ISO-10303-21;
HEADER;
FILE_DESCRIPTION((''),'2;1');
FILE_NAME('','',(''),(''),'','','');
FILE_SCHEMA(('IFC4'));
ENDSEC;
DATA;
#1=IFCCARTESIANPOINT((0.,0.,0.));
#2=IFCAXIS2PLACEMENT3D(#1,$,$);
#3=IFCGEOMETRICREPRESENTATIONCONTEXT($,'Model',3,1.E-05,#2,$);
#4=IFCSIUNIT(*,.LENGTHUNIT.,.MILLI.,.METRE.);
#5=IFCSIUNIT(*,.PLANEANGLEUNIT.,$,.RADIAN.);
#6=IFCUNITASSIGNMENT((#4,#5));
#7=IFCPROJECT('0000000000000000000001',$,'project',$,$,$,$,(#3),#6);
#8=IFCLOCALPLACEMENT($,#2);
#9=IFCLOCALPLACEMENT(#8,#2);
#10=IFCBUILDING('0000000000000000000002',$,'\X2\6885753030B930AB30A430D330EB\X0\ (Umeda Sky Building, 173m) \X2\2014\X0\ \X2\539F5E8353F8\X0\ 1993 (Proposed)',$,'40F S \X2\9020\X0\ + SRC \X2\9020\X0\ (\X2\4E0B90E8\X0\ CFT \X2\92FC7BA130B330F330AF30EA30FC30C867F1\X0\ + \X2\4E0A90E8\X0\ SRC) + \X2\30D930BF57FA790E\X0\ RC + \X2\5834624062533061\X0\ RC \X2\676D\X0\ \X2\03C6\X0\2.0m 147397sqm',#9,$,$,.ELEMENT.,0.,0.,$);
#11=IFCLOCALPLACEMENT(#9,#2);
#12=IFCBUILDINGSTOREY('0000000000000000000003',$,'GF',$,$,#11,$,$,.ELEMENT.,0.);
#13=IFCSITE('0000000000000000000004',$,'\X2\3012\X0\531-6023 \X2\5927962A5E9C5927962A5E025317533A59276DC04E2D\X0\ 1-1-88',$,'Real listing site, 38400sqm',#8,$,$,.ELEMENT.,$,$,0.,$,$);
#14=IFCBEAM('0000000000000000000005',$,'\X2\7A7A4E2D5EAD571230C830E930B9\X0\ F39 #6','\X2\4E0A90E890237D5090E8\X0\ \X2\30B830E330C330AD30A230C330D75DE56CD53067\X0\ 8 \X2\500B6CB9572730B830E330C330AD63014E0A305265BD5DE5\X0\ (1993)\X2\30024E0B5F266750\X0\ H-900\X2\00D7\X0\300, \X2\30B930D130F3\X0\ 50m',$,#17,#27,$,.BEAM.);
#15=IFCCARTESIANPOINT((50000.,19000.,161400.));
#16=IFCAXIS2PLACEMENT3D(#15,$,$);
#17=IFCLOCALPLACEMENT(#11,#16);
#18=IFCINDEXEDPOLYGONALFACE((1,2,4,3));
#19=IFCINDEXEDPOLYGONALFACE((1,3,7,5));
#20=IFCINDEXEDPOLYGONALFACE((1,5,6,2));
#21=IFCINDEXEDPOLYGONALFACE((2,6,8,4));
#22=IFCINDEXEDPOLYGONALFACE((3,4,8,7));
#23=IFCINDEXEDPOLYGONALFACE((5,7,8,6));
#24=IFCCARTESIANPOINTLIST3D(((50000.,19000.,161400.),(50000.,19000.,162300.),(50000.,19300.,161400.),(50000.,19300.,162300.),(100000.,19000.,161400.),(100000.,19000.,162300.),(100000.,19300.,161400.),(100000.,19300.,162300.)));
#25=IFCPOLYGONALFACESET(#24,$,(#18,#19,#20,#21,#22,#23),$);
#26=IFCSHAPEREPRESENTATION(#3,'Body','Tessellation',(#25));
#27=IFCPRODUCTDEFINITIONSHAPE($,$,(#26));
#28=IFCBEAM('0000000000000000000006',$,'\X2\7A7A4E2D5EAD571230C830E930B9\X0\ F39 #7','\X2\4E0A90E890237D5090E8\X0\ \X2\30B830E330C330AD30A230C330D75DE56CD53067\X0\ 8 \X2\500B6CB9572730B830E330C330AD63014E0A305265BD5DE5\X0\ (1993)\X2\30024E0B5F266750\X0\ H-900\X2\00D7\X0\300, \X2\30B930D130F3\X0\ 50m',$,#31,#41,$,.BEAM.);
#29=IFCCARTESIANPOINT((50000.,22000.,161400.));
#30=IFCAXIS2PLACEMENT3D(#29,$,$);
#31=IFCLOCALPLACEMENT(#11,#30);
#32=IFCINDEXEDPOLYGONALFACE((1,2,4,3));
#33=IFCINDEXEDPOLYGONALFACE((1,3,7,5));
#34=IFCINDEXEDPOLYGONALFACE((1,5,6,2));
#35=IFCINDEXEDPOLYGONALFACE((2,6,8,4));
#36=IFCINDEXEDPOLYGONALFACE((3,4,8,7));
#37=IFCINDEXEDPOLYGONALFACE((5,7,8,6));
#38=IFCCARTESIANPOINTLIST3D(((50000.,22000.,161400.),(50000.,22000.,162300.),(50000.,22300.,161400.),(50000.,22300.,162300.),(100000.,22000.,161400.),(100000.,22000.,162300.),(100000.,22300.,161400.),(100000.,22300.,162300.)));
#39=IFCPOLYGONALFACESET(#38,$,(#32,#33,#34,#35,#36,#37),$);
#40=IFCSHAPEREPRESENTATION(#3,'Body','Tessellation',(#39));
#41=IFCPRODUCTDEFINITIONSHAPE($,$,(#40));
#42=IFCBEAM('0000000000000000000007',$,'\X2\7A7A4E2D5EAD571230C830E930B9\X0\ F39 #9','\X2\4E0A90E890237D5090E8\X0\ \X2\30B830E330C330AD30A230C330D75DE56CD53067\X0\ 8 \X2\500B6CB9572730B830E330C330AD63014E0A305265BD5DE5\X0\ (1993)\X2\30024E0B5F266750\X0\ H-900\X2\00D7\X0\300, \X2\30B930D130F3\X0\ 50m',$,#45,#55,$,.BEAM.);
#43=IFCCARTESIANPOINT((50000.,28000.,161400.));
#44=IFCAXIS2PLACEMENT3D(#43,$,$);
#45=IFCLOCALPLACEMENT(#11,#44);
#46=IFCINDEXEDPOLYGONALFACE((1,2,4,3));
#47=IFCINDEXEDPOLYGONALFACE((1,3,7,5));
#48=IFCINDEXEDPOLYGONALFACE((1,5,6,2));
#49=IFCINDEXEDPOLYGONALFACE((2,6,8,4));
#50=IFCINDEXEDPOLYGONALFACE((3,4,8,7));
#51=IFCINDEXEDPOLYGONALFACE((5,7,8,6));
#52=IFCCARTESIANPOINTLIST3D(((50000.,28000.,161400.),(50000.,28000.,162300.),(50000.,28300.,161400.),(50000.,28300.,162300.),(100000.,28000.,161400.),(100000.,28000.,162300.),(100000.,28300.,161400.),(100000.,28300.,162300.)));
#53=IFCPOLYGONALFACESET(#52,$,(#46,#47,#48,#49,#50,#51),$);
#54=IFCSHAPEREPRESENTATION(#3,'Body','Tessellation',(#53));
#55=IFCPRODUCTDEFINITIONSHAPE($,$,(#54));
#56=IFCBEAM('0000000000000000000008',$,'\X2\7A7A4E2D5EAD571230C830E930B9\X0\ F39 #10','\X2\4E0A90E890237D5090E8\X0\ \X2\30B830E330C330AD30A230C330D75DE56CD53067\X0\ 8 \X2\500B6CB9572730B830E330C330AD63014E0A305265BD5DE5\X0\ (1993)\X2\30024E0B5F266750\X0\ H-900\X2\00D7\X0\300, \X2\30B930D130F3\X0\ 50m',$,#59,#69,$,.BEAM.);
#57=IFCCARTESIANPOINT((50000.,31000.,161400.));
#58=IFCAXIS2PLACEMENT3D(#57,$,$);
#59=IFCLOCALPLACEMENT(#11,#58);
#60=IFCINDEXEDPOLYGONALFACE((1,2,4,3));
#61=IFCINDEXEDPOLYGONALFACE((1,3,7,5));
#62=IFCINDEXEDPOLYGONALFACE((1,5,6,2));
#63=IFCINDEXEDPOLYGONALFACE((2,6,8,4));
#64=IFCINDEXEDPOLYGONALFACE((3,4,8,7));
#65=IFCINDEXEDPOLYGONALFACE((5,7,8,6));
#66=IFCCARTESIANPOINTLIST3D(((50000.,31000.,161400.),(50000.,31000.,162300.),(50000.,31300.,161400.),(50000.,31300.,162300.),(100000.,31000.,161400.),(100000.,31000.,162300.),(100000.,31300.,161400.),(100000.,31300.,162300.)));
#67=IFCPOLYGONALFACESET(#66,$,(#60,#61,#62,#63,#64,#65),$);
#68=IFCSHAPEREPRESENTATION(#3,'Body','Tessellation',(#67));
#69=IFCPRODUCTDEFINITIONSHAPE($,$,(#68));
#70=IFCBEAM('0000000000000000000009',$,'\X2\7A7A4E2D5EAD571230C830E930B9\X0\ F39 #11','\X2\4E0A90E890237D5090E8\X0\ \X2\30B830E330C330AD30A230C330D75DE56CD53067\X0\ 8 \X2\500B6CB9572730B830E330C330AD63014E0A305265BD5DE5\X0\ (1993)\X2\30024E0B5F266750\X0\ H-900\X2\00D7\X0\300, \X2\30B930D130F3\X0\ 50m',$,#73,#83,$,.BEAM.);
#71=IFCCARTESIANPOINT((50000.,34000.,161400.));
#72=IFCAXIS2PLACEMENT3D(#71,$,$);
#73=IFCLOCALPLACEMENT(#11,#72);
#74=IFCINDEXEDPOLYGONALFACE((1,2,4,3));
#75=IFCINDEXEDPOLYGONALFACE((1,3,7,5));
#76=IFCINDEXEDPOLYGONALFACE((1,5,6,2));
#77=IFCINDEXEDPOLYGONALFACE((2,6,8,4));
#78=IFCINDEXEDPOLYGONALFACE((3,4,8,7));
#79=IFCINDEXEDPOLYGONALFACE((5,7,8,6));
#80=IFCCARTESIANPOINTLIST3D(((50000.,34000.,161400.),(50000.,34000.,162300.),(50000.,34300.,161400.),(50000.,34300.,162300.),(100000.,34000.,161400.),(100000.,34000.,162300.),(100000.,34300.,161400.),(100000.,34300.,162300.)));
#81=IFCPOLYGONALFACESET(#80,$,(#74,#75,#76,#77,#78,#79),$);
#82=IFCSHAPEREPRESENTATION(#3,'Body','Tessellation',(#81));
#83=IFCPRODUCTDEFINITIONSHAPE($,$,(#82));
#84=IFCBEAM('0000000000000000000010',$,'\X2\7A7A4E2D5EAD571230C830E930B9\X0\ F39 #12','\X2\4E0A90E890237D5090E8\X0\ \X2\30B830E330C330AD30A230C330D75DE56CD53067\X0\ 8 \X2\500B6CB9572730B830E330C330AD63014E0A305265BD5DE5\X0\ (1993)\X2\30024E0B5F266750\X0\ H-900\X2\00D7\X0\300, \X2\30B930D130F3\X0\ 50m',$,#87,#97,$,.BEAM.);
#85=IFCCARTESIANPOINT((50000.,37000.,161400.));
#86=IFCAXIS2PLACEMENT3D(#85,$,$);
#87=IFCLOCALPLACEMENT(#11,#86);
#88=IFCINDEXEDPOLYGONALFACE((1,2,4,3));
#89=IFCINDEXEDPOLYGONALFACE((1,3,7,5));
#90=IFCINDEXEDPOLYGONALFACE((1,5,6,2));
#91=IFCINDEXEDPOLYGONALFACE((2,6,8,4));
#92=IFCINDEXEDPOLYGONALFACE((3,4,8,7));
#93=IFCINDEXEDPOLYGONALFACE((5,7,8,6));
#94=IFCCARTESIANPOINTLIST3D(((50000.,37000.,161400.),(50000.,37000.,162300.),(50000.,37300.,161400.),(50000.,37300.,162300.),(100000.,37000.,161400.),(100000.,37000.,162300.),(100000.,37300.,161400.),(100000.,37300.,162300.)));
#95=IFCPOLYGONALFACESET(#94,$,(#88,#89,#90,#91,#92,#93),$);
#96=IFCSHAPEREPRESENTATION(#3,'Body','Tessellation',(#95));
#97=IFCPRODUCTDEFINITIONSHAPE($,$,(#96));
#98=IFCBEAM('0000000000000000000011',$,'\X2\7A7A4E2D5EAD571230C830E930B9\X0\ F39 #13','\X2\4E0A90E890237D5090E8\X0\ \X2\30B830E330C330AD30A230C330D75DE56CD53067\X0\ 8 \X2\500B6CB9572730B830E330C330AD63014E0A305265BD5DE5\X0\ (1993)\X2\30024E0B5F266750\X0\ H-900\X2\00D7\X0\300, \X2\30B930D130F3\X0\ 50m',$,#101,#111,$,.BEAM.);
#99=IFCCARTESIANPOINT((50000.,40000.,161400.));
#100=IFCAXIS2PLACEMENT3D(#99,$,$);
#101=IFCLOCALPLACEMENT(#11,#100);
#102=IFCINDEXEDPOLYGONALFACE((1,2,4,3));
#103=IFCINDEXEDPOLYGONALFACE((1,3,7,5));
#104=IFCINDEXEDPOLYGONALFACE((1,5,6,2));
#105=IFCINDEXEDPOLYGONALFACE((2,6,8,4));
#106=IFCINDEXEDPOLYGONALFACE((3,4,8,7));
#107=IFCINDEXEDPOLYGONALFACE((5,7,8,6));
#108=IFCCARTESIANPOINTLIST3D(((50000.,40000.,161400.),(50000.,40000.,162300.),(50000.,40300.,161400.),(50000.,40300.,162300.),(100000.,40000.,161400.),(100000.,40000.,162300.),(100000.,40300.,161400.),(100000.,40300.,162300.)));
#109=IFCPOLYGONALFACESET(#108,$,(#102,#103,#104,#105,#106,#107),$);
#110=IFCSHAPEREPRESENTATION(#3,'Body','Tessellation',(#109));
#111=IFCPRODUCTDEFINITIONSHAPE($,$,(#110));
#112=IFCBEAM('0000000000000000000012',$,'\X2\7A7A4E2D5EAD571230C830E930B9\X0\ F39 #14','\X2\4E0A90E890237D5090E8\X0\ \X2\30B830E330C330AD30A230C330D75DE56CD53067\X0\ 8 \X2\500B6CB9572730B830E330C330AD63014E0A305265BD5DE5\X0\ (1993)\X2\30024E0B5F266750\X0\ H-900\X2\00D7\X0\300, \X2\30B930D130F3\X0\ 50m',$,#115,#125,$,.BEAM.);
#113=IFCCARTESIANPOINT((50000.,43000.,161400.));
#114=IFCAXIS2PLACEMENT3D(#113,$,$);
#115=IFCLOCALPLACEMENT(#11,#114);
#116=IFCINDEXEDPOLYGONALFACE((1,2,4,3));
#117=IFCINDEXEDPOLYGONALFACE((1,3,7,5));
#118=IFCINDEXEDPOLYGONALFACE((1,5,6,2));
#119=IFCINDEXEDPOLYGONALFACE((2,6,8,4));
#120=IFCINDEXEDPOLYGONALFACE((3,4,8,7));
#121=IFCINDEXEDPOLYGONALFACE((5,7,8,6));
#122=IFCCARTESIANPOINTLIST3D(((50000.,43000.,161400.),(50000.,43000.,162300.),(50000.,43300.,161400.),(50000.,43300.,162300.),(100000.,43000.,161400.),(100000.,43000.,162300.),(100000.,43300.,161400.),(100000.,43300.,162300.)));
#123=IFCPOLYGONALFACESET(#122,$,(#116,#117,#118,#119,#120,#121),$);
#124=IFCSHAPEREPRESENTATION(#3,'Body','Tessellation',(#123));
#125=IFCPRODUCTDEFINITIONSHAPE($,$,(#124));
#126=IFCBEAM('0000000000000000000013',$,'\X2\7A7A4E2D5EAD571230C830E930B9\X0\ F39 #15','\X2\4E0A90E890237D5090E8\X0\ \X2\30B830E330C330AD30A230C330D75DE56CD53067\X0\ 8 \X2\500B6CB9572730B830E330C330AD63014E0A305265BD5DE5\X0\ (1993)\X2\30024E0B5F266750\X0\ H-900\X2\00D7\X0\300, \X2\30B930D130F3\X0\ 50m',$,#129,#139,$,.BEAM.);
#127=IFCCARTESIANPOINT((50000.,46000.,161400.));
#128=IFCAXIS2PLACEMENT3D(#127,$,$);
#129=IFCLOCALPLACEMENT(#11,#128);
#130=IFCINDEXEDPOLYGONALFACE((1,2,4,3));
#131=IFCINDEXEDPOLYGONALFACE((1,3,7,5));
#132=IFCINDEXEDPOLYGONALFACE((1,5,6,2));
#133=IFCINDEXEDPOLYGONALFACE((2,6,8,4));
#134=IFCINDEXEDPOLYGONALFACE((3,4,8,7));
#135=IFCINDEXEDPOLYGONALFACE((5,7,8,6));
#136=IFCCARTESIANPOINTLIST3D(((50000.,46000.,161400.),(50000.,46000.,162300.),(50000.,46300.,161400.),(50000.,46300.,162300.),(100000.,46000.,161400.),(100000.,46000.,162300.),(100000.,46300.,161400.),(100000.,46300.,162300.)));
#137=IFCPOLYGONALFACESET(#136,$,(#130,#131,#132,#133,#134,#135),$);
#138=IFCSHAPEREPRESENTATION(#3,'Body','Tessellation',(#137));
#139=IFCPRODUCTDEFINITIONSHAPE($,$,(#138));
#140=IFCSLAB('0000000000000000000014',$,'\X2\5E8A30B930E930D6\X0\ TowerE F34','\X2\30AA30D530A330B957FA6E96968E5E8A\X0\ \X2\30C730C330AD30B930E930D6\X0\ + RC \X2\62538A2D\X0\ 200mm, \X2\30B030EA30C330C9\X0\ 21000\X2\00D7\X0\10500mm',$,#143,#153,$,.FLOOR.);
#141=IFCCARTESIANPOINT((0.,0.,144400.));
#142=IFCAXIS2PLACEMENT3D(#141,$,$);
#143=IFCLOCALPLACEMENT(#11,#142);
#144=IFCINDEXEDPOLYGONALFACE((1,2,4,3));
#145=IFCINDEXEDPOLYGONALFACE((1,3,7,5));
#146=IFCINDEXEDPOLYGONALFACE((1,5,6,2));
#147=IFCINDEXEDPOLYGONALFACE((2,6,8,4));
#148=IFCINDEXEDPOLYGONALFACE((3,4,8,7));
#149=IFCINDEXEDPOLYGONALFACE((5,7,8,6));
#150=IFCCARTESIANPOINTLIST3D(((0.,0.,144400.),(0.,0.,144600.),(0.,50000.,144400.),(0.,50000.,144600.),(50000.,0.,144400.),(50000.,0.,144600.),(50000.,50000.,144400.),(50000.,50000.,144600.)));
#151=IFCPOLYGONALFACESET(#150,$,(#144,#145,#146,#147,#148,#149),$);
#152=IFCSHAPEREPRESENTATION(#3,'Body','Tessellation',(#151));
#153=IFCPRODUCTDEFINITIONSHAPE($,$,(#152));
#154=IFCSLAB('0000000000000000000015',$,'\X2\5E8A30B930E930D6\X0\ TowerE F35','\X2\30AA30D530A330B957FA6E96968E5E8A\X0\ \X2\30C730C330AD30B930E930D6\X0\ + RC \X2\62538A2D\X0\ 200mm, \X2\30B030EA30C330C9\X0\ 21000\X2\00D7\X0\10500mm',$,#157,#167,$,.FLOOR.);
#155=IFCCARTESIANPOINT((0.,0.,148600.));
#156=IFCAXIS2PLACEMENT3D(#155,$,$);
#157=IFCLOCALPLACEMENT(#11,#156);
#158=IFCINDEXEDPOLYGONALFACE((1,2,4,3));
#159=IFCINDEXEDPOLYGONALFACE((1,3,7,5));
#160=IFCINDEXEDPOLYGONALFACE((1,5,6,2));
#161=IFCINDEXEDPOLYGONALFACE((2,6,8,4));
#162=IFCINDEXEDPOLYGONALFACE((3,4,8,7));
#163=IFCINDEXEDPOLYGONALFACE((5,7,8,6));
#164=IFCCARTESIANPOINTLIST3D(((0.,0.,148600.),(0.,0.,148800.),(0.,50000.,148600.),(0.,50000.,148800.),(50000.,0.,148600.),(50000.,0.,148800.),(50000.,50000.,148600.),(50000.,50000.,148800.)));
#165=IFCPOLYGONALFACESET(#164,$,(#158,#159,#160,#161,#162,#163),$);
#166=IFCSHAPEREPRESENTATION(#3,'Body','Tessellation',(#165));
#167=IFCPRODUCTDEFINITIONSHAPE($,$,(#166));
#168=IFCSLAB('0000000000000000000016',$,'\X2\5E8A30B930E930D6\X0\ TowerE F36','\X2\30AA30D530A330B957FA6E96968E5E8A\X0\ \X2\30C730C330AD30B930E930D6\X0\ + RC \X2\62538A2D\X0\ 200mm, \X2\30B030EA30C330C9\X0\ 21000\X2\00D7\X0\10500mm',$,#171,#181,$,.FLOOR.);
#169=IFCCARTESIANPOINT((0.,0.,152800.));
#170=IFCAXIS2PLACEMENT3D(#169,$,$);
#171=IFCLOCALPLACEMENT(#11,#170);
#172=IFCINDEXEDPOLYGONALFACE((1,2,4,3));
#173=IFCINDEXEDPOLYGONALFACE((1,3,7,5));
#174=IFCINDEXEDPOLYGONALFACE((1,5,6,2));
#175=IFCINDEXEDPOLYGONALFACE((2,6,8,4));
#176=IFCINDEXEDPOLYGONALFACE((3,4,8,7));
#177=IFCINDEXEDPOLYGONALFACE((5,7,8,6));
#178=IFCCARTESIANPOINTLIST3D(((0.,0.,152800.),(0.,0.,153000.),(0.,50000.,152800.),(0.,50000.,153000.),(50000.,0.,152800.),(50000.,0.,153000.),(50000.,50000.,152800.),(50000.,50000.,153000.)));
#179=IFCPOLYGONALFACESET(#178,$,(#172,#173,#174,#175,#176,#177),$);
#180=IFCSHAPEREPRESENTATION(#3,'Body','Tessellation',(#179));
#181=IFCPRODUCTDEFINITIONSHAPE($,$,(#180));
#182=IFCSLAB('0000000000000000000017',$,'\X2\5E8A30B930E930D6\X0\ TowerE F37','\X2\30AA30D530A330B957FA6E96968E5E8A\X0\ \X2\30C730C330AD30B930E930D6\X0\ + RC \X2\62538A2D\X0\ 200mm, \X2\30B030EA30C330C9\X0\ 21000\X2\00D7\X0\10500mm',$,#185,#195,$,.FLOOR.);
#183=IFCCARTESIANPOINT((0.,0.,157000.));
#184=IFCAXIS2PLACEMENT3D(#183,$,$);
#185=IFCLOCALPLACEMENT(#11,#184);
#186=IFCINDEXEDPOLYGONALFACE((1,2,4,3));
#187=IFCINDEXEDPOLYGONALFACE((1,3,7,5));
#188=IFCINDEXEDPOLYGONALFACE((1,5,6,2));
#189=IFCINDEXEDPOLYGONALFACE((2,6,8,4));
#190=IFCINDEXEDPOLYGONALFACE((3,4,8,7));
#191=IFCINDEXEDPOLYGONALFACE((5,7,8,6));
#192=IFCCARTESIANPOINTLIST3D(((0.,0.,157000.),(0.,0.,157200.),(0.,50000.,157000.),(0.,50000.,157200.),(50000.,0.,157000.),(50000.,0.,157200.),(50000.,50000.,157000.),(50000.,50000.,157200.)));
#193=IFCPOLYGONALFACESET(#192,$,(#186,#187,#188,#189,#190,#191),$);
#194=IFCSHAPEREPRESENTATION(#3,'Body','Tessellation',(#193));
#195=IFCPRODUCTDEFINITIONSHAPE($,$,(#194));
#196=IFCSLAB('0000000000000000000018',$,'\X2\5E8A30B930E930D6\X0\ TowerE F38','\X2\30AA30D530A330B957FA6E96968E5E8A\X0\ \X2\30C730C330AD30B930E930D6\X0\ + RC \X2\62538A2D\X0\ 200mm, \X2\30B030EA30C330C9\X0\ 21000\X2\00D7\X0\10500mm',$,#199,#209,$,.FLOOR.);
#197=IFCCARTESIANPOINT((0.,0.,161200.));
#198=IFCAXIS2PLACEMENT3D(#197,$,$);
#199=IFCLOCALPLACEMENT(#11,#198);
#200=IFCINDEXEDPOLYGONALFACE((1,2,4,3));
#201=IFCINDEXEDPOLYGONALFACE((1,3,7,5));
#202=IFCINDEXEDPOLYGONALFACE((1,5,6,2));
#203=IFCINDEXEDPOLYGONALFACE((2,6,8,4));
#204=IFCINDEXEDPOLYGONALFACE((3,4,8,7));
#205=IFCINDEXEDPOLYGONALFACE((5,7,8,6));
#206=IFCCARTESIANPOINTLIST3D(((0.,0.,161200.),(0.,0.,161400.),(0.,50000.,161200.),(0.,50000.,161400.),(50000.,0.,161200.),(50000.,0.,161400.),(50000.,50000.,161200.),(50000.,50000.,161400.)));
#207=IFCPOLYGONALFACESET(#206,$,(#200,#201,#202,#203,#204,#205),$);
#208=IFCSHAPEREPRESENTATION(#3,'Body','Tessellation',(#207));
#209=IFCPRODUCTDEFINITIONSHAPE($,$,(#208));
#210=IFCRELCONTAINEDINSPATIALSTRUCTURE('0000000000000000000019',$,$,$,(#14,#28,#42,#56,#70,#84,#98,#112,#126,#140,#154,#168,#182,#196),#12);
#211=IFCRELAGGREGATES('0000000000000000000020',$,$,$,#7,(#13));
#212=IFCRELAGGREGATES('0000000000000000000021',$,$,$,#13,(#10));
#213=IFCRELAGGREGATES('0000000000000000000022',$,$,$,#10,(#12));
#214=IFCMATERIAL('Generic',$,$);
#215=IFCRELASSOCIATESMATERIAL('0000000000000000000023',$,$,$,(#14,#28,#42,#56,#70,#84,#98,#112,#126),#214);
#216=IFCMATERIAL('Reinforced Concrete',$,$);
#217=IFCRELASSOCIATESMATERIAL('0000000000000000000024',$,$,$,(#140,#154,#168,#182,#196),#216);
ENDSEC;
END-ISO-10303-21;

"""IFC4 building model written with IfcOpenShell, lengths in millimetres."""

from ifc_helpers import new_model, si_unit, frame, frame_2d, origin, place, context, project, spatial, rectangle, extrude, material, element, save


model = new_model("IFC4")

# Units and contexts
model_context = context("Model", 3, precision=1e-05, world=origin())
ifc_project = project(units=[si_unit("LENGTHUNIT", "METRE", prefix="MILLI"), si_unit("PLANEANGLEUNIT", "RADIAN")], contexts=[model_context])

# Site, building, storey
site_placement = place(None, origin())
site = spatial("IfcSite", under=ifc_project, at=site_placement, Name="〒531-6023 大阪府大阪市北区大淀中 1-1-88", ObjectType="Real listing site, 38400sqm", CompositionType="ELEMENT", RefElevation=0.0)
building_placement = place(site_placement, origin())
building = spatial("IfcBuilding", under=site, at=building_placement, Name="梅田スカイビル (Umeda Sky Building, 173m) — 原広司 1993 (Proposed)", ObjectType="40F S 造 + SRC 造 (下部 CFT 鋼管コンクリート柱 + 上部 SRC) + ベタ基礎 RC + 場所打ち RC 杭 φ2.0m 147397sqm", CompositionType="ELEMENT", ElevationOfRefHeight=0.0, ElevationOfTerrain=0.0)
storey_placement = place(building_placement, origin())
storey = spatial("IfcBuildingStorey", under=building, at=storey_placement, Name="GF", CompositionType="ELEMENT", Elevation=0.0)

# Shared definitions
ifc_material_1 = material(Name="Reinforced Concrete")

# Beams
ifc_material_2 = material(Name="Generic")
beam_1_placement = place(storey_placement, frame((50000.0, 19000.0, 161400.0)))
element("IfcBeam", 1, at=beam_1_placement, inside=storey, material=ifc_material_2, Name="空中庭園トラス F39 #6", Description="上部連結部 ジャッキアップ工法で 8 個油圧ジャッキ持上げ施工 (1993)。下弦材 H-900×300, スパン 50m", PredefinedType="BEAM", context=model_context, shape_type="SweptSolid", body=[
    extrude(rectangle(XDim=50000.0, YDim=300.0, at=frame_2d((25000.0, 150.0))), frame((50000.0, 19000.0, 161400.0)), (0.0, 0.0, 1.0), 900.0),
])
beam_2_placement = place(storey_placement, frame((50000.0, 22000.0, 161400.0)))
element("IfcBeam", 2, at=beam_2_placement, inside=storey, material=ifc_material_2, Name="空中庭園トラス F39 #7", Description="上部連結部 ジャッキアップ工法で 8 個油圧ジャッキ持上げ施工 (1993)。下弦材 H-900×300, スパン 50m", PredefinedType="BEAM", context=model_context, shape_type="SweptSolid", body=[
    extrude(rectangle(XDim=50000.0, YDim=300.0, at=frame_2d((25000.0, 150.0))), frame((50000.0, 22000.0, 161400.0)), (0.0, 0.0, 1.0), 900.0),
])
beam_3_placement = place(storey_placement, frame((50000.0, 28000.0, 161400.0)))
element("IfcBeam", 3, at=beam_3_placement, inside=storey, material=ifc_material_2, Name="空中庭園トラス F39 #9", Description="上部連結部 ジャッキアップ工法で 8 個油圧ジャッキ持上げ施工 (1993)。下弦材 H-900×300, スパン 50m", PredefinedType="BEAM", context=model_context, shape_type="SweptSolid", body=[
    extrude(rectangle(XDim=50000.0, YDim=300.0, at=frame_2d((25000.0, 150.0))), frame((50000.0, 28000.0, 161400.0)), (0.0, 0.0, 1.0), 900.0),
])
beam_4_placement = place(storey_placement, frame((50000.0, 31000.0, 161400.0)))
element("IfcBeam", 4, at=beam_4_placement, inside=storey, material=ifc_material_2, Name="空中庭園トラス F39 #10", Description="上部連結部 ジャッキアップ工法で 8 個油圧ジャッキ持上げ施工 (1993)。下弦材 H-900×300, スパン 50m", PredefinedType="BEAM", context=model_context, shape_type="SweptSolid", body=[
    extrude(rectangle(XDim=50000.0, YDim=300.0, at=frame_2d((25000.0, 150.0))), frame((50000.0, 31000.0, 161400.0)), (0.0, 0.0, 1.0), 900.0),
])
beam_5_placement = place(storey_placement, frame((50000.0, 34000.0, 161400.0)))
element("IfcBeam", 5, at=beam_5_placement, inside=storey, material=ifc_material_2, Name="空中庭園トラス F39 #11", Description="上部連結部 ジャッキアップ工法で 8 個油圧ジャッキ持上げ施工 (1993)。下弦材 H-900×300, スパン 50m", PredefinedType="BEAM", context=model_context, shape_type="SweptSolid", body=[
    extrude(rectangle(XDim=50000.0, YDim=300.0, at=frame_2d((25000.0, 150.0))), frame((50000.0, 34000.0, 161400.0)), (0.0, 0.0, 1.0), 900.0),
])
beam_6_placement = place(storey_placement, frame((50000.0, 37000.0, 161400.0)))
element("IfcBeam", 6, at=beam_6_placement, inside=storey, material=ifc_material_2, Name="空中庭園トラス F39 #12", Description="上部連結部 ジャッキアップ工法で 8 個油圧ジャッキ持上げ施工 (1993)。下弦材 H-900×300, スパン 50m", PredefinedType="BEAM", context=model_context, shape_type="SweptSolid", body=[
    extrude(rectangle(XDim=50000.0, YDim=300.0, at=frame_2d((25000.0, 150.0))), frame((50000.0, 37000.0, 161400.0)), (0.0, 0.0, 1.0), 900.0),
])
beam_7_placement = place(storey_placement, frame((50000.0, 40000.0, 161400.0)))
element("IfcBeam", 7, at=beam_7_placement, inside=storey, material=ifc_material_2, Name="空中庭園トラス F39 #13", Description="上部連結部 ジャッキアップ工法で 8 個油圧ジャッキ持上げ施工 (1993)。下弦材 H-900×300, スパン 50m", PredefinedType="BEAM", context=model_context, shape_type="SweptSolid", body=[
    extrude(rectangle(XDim=50000.0, YDim=300.0, at=frame_2d((25000.0, 150.0))), frame((50000.0, 40000.0, 161400.0)), (0.0, 0.0, 1.0), 900.0),
])
beam_8_placement = place(storey_placement, frame((50000.0, 43000.0, 161400.0)))
element("IfcBeam", 8, at=beam_8_placement, inside=storey, material=ifc_material_2, Name="空中庭園トラス F39 #14", Description="上部連結部 ジャッキアップ工法で 8 個油圧ジャッキ持上げ施工 (1993)。下弦材 H-900×300, スパン 50m", PredefinedType="BEAM", context=model_context, shape_type="SweptSolid", body=[
    extrude(rectangle(XDim=50000.0, YDim=300.0, at=frame_2d((25000.0, 150.0))), frame((50000.0, 43000.0, 161400.0)), (0.0, 0.0, 1.0), 900.0),
])
beam_9_placement = place(storey_placement, frame((50000.0, 46000.0, 161400.0)))
element("IfcBeam", 9, at=beam_9_placement, inside=storey, material=ifc_material_2, Name="空中庭園トラス F39 #15", Description="上部連結部 ジャッキアップ工法で 8 個油圧ジャッキ持上げ施工 (1993)。下弦材 H-900×300, スパン 50m", PredefinedType="BEAM", context=model_context, shape_type="SweptSolid", body=[
    extrude(rectangle(XDim=50000.0, YDim=300.0, at=frame_2d((25000.0, 150.0))), frame((50000.0, 46000.0, 161400.0)), (0.0, 0.0, 1.0), 900.0),
])

# Slabs
slab_1_placement = place(storey_placement, frame((0.0, 0.0, 144400.0)))
element("IfcSlab", 10, at=slab_1_placement, inside=storey, material=ifc_material_1, Name="床スラブ TowerE F34", Description="オフィス基準階床 デッキスラブ + RC 打設 200mm, グリッド 21000×10500mm", PredefinedType="FLOOR", context=model_context, shape_type="SweptSolid", body=[
    extrude(rectangle(XDim=50000.0, YDim=50000.0, at=frame_2d((25000.0, 25000.0))), frame((0.0, 0.0, 144400.0)), (0.0, 0.0, 1.0), 200.0),
])
slab_2_placement = place(storey_placement, frame((0.0, 0.0, 148600.0)))
element("IfcSlab", 11, at=slab_2_placement, inside=storey, material=ifc_material_1, Name="床スラブ TowerE F35", Description="オフィス基準階床 デッキスラブ + RC 打設 200mm, グリッド 21000×10500mm", PredefinedType="FLOOR", context=model_context, shape_type="SweptSolid", body=[
    extrude(rectangle(XDim=50000.0, YDim=50000.0, at=frame_2d((25000.0, 25000.0))), frame((0.0, 0.0, 148600.0)), (0.0, 0.0, 1.0), 200.0),
])
slab_3_placement = place(storey_placement, frame((0.0, 0.0, 152800.0)))
element("IfcSlab", 12, at=slab_3_placement, inside=storey, material=ifc_material_1, Name="床スラブ TowerE F36", Description="オフィス基準階床 デッキスラブ + RC 打設 200mm, グリッド 21000×10500mm", PredefinedType="FLOOR", context=model_context, shape_type="SweptSolid", body=[
    extrude(rectangle(XDim=50000.0, YDim=50000.0, at=frame_2d((25000.0, 25000.0))), frame((0.0, 0.0, 152800.0)), (0.0, 0.0, 1.0), 200.0),
])
slab_4_placement = place(storey_placement, frame((0.0, 0.0, 157000.0)))
element("IfcSlab", 13, at=slab_4_placement, inside=storey, material=ifc_material_1, Name="床スラブ TowerE F37", Description="オフィス基準階床 デッキスラブ + RC 打設 200mm, グリッド 21000×10500mm", PredefinedType="FLOOR", context=model_context, shape_type="SweptSolid", body=[
    extrude(rectangle(XDim=50000.0, YDim=50000.0, at=frame_2d((25000.0, 25000.0))), frame((0.0, 0.0, 157000.0)), (0.0, 0.0, 1.0), 200.0),
])
slab_5_placement = place(storey_placement, frame((0.0, 0.0, 161200.0)))
element("IfcSlab", 14, at=slab_5_placement, inside=storey, material=ifc_material_1, Name="床スラブ TowerE F38", Description="オフィス基準階床 デッキスラブ + RC 打設 200mm, グリッド 21000×10500mm", PredefinedType="FLOOR", context=model_context, shape_type="SweptSolid", body=[
    extrude(rectangle(XDim=50000.0, YDim=50000.0, at=frame_2d((25000.0, 25000.0))), frame((0.0, 0.0, 161200.0)), (0.0, 0.0, 1.0), 200.0),
])

save(model, "model.ifc")
